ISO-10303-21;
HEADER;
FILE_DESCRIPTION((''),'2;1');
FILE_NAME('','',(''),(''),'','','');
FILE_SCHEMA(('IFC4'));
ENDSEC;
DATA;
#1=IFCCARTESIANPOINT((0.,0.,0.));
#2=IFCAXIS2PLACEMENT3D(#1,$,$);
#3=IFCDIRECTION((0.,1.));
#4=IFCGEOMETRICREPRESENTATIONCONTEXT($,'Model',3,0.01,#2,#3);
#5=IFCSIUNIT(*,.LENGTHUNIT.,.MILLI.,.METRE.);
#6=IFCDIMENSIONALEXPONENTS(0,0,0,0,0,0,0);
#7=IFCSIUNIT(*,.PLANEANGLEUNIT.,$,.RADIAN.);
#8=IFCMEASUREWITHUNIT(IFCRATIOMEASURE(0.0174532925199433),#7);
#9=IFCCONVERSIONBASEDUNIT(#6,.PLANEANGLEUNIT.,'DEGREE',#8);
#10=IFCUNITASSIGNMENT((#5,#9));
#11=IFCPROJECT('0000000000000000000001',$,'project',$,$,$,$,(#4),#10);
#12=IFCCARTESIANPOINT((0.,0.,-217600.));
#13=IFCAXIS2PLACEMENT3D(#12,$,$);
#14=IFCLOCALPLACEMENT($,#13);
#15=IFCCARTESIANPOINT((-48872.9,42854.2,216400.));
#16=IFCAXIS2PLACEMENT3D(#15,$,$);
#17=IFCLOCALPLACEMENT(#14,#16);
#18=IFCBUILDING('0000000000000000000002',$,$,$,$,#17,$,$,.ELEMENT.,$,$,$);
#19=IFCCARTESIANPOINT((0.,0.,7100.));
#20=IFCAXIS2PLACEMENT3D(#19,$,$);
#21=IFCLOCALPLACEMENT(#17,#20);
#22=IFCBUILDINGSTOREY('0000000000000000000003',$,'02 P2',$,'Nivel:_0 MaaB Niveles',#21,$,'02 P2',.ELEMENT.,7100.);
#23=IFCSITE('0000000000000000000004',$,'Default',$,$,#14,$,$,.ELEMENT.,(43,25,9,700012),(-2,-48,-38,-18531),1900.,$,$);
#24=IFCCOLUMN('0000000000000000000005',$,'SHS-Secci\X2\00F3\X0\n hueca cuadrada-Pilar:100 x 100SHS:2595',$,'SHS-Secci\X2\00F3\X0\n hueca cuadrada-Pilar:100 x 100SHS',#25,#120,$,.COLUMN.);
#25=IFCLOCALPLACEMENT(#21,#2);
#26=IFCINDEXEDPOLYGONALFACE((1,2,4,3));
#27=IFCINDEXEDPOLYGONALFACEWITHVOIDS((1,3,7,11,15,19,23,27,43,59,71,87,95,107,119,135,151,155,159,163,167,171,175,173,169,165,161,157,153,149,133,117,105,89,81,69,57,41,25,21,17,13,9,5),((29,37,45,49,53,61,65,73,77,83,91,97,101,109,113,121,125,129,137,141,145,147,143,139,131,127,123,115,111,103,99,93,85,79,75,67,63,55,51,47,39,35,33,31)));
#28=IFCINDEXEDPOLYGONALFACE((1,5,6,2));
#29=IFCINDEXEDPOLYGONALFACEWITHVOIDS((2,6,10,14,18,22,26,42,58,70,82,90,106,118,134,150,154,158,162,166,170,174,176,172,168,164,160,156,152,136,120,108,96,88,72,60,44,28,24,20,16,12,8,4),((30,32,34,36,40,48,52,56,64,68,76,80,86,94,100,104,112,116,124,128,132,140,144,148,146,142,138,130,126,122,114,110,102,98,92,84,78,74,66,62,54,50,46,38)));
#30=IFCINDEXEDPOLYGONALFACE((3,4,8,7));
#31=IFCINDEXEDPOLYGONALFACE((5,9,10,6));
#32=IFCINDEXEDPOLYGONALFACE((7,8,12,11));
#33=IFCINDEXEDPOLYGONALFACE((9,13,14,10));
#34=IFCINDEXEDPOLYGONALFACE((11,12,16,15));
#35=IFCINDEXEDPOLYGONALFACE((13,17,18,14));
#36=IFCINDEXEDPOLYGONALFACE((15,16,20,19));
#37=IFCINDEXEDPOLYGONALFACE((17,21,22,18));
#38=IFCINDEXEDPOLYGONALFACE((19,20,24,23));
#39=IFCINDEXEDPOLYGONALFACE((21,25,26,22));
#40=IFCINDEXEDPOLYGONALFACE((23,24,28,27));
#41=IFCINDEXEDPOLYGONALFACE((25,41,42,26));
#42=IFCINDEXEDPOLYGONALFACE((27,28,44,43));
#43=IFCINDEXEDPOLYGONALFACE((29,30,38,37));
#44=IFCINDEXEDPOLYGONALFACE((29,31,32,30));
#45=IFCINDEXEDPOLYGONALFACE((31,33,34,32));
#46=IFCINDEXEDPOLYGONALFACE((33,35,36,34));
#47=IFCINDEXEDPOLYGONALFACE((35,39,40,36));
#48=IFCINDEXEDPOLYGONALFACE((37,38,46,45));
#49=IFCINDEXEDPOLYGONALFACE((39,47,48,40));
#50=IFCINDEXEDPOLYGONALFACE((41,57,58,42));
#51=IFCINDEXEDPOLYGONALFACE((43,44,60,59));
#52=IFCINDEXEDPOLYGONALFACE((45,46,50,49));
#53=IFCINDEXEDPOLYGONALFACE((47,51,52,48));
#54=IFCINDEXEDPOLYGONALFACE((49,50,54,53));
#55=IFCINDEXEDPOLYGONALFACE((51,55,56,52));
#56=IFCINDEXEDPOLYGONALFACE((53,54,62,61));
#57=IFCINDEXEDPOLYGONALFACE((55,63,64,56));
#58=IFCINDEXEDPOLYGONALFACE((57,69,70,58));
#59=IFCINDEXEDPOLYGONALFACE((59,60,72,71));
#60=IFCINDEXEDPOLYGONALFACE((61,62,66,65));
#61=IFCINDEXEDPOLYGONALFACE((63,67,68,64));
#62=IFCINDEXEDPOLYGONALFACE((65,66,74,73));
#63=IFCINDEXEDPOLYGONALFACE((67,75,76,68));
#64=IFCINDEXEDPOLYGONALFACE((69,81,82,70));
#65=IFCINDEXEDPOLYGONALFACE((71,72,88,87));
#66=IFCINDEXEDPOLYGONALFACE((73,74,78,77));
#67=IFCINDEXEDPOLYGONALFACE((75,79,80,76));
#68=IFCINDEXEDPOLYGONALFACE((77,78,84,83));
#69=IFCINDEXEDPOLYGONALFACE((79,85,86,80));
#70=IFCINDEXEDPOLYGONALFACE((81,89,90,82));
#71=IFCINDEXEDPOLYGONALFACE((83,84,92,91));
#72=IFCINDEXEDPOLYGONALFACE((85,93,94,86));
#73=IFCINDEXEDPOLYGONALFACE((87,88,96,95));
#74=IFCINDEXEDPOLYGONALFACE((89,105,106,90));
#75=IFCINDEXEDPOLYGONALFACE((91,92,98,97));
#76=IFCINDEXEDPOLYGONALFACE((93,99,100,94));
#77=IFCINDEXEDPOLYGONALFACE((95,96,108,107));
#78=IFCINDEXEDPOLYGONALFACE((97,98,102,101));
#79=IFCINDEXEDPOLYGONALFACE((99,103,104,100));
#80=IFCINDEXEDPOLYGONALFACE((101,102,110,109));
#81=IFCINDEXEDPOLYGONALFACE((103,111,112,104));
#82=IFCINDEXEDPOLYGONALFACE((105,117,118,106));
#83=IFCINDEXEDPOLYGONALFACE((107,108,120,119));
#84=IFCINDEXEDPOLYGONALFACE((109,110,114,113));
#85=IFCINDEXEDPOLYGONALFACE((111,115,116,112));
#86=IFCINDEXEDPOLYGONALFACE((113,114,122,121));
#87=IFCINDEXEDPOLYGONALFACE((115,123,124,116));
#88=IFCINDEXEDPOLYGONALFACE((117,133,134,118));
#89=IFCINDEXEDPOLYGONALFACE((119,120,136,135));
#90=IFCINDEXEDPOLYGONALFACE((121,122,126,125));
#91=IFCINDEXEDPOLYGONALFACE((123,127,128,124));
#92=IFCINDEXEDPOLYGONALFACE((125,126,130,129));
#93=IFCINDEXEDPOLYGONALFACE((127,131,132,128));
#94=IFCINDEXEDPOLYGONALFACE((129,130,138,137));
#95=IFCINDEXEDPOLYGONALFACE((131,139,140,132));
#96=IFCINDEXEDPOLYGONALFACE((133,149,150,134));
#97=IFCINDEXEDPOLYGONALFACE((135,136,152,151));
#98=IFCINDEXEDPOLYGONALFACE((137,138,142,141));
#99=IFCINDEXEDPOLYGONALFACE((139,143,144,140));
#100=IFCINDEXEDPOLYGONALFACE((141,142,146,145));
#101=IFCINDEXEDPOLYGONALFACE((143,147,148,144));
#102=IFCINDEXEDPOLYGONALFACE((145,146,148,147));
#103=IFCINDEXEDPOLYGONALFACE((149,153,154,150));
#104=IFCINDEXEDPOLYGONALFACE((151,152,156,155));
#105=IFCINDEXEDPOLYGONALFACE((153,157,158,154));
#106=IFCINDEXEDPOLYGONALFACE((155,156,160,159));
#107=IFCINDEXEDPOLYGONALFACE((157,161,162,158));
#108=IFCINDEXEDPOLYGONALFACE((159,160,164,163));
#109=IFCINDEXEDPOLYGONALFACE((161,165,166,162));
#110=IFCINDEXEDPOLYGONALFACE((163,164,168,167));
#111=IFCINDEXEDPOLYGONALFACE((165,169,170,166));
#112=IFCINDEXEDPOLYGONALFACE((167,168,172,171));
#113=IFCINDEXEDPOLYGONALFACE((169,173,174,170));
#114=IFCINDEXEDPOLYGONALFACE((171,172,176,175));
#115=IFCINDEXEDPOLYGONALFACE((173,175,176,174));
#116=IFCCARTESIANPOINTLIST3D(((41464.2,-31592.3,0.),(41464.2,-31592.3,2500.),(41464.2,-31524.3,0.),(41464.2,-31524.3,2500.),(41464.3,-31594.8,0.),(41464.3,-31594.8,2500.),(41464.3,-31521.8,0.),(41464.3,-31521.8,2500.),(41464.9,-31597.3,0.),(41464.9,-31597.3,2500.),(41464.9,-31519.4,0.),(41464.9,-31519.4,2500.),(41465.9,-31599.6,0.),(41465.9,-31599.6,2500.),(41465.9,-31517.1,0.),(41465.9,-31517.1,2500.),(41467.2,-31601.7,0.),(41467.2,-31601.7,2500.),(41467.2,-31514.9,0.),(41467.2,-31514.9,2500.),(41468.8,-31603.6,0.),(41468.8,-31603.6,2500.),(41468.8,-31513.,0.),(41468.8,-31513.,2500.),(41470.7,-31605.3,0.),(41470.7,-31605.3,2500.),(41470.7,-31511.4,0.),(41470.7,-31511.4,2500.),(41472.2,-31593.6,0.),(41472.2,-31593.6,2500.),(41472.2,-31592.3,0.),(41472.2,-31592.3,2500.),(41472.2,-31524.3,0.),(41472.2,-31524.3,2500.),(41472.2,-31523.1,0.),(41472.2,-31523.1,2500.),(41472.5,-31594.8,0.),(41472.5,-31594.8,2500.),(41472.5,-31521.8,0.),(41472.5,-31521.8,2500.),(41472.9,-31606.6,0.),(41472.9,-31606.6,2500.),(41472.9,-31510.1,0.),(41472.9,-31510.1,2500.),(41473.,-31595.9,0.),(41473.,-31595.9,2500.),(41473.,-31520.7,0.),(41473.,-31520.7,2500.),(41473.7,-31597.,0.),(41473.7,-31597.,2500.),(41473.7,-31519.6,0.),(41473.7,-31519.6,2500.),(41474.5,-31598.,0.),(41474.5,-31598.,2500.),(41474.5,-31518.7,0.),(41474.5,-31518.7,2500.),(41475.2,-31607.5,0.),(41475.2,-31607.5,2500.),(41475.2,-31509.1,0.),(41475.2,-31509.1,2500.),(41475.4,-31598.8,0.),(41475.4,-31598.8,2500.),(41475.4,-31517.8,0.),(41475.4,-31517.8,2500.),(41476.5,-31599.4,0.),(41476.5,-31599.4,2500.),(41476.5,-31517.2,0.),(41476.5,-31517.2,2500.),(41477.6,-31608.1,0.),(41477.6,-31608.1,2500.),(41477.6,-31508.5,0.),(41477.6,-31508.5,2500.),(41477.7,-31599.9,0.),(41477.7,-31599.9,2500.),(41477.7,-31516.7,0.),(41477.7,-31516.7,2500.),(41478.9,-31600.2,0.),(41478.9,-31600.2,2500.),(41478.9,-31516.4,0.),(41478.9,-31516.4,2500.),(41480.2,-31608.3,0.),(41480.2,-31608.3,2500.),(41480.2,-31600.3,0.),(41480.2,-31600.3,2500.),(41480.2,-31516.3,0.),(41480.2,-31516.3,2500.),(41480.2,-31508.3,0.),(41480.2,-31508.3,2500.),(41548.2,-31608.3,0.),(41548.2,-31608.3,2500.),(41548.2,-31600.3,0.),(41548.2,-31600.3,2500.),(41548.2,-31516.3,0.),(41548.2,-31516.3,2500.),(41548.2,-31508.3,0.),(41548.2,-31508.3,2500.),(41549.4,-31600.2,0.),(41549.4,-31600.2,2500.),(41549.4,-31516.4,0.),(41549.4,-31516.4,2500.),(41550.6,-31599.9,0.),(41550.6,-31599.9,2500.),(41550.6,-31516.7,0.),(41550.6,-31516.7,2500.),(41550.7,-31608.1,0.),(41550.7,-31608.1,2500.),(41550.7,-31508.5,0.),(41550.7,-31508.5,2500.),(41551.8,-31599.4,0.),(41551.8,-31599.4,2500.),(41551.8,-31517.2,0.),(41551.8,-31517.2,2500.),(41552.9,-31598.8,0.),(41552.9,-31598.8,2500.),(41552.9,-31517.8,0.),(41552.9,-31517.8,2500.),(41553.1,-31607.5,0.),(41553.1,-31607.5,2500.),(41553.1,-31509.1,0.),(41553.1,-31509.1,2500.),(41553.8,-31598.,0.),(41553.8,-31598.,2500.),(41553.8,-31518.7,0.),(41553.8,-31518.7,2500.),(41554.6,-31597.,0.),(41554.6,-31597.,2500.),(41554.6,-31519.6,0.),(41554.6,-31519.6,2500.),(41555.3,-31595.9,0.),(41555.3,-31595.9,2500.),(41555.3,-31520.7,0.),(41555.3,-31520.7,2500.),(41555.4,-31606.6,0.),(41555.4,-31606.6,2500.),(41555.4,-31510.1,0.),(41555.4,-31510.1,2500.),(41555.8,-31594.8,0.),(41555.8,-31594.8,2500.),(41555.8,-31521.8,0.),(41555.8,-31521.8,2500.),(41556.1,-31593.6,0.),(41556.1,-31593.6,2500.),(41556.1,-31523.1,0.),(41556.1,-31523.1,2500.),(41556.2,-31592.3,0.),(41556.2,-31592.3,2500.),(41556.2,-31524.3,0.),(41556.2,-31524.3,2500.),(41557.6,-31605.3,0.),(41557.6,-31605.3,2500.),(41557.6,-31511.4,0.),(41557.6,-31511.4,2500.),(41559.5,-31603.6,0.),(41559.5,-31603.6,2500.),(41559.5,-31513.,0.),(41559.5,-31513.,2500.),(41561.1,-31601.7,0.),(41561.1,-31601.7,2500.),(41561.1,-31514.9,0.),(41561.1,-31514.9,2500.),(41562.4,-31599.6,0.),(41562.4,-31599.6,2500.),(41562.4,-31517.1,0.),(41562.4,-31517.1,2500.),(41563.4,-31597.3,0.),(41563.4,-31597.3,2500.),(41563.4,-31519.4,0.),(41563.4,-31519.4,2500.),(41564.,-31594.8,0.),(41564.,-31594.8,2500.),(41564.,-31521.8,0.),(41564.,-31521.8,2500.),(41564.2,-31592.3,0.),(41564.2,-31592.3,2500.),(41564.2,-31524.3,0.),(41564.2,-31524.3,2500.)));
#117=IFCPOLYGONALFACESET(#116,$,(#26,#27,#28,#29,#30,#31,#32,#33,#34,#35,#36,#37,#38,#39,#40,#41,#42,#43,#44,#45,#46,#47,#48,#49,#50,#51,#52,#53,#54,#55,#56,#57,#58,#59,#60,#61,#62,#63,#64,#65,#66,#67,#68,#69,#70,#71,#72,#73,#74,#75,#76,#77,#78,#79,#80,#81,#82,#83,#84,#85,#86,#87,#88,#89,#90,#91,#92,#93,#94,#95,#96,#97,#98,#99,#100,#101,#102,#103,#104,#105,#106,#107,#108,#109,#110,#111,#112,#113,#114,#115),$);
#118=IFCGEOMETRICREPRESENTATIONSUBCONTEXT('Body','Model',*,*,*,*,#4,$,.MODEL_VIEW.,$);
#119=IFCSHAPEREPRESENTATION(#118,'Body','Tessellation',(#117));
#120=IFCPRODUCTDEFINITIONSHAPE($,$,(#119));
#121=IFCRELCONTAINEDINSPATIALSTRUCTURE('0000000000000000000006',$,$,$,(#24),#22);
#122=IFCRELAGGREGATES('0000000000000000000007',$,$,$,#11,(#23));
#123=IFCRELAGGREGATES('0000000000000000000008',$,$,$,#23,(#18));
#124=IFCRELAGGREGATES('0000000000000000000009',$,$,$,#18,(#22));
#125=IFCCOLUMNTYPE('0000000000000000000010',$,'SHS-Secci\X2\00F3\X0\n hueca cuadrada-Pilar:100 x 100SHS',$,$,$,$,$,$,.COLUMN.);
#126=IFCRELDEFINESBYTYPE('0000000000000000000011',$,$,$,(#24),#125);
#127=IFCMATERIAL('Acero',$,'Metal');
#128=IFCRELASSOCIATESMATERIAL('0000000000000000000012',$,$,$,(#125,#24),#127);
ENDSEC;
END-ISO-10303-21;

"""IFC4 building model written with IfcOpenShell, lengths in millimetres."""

from ifc_helpers import new_model, entity, si_unit, converted_unit, direction, frame, origin, place, context, subcontext, project, spatial, indexed_curve, outline, extrude, source, transform, mapped, material, type_object, type_shapes, element, save


model = new_model("IFC4")

# Units and contexts
model_context = context("Model", 3, precision=0.01, world=origin(), true_north=direction((0.0, 1.0)))
body_context = subcontext(model_context, "Body", "Model", "MODEL_VIEW")
ifc_project = project(units=[si_unit("LENGTHUNIT", "METRE", prefix="MILLI"), converted_unit("PLANEANGLEUNIT", "DEGREE", entity("IfcRatioMeasure", 0.0174532925199433), si_unit("PLANEANGLEUNIT", "RADIAN"), dimensions=[0, 0, 0, 0, 0, 0, 0])], contexts=[model_context])

# Site, building, storey
site_placement = place(None, frame((0.0, 0.0, -217600.0)))
site = spatial("IfcSite", under=ifc_project, at=site_placement, Name="Default", CompositionType="ELEMENT", RefLatitude=(43, 25, 9, 700012), RefLongitude=(-2, -48, -38, -18531), RefElevation=1900.0)
building_placement = place(site_placement, frame((-48872.9, 42854.2, 216400.0)))
building = spatial("IfcBuilding", under=site, at=building_placement, CompositionType="ELEMENT")
storey_placement = place(building_placement, frame((0.0, 0.0, 7100.0)))
storey = spatial("IfcBuildingStorey", under=building, at=storey_placement, Name="02 P2", ObjectType="Nivel:_0 MaaB Niveles", LongName="02 P2", CompositionType="ELEMENT", Elevation=7100.0)

# Column
ifc_material_1 = material(Name="Acero", Category="Metal")
column_type_1 = type_object("IfcColumnType", Name="SHS-Sección hueca cuadrada-Pilar:100 x 100SHS", PredefinedType="COLUMN", material=ifc_material_1)
shared_shape_1 = source(origin(), body_context, "Body", "SweptSolid", [
    extrude(outline(indexed_curve([(-34.0, -50.0), (34.0, -50.0), (36.5, -49.8), (38.9, -49.2), (41.3, -48.3), (43.4, -46.9), (45.3, -45.3), (46.9, -43.4), (48.3, -41.3), (49.2, -38.9), (49.8, -36.5), (50.0, -34.0), (50.0, 34.0), (49.8, 36.5), (49.2, 38.9), (48.3, 41.3), (46.9, 43.4), (45.3, 45.3), (43.4, 46.9), (41.3, 48.3), (38.9, 49.2), (36.5, 49.8), (34.0, 50.0), (-34.0, 50.0), (-36.5, 49.8), (-38.9, 49.2), (-41.3, 48.3), (-43.4, 46.9), (-45.3, 45.3), (-46.9, 43.4), (-48.3, 41.3), (-49.2, 38.9), (-49.8, 36.5), (-50.0, 34.0), (-50.0, -34.0), (-49.8, -36.5), (-49.2, -38.9), (-48.3, -41.3), (-46.9, -43.4), (-45.3, -45.3), (-43.4, -46.9), (-41.3, -48.3), (-38.9, -49.2), (-36.5, -49.8), (-34.0, -50.0)], self_intersect=False), holes=[indexed_curve([(-42.0, 34.0), (-41.9, 35.3), (-41.6, 36.5), (-41.1, 37.6), (-40.5, 38.7), (-39.7, 39.7), (-38.7, 40.5), (-37.6, 41.1), (-36.5, 41.6), (-35.3, 41.9), (-34.0, 42.0), (34.0, 42.0), (35.3, 41.9), (36.5, 41.6), (37.6, 41.1), (38.7, 40.5), (39.7, 39.7), (40.5, 38.7), (41.1, 37.6), (41.6, 36.5), (41.9, 35.3), (42.0, 34.0), (42.0, -34.0), (41.9, -35.3), (41.6, -36.5), (41.1, -37.6), (40.5, -38.7), (39.7, -39.7), (38.7, -40.5), (37.6, -41.1), (36.5, -41.6), (35.3, -41.9), (34.0, -42.0), (-34.0, -42.0), (-35.3, -41.9), (-36.5, -41.6), (-37.6, -41.1), (-38.7, -40.5), (-39.7, -39.7), (-40.5, -38.7), (-41.1, -37.6), (-41.6, -36.5), (-41.9, -35.3), (-42.0, -34.0), (-42.0, 34.0)], self_intersect=False)]), frame((0.0, 0.0, 7100.0), z_axis=(0.0, 0.0, 1.0), x_axis=(0.0, 1.0, 0.0)), (0.0, 0.0, 1.0), 2500.0),
])
type_shapes(column_type_1, [shared_shape_1])
column_1_placement = place(storey_placement, frame((41514.2, -31558.3, -7100.0), z_axis=(0.0, 0.0, 1.0), x_axis=(0.0, -1.0, 0.0)))
element("IfcColumn", 1, at=column_1_placement, inside=storey, type_object=column_type_1, material=ifc_material_1, Name="SHS-Sección hueca cuadrada-Pilar:100 x 100SHS:2595", ObjectType="SHS-Sección hueca cuadrada-Pilar:100 x 100SHS", PredefinedType="COLUMN", context=body_context, shape_type="MappedRepresentation", body=[
    mapped(shared_shape_1, transform((0.0, 0.0, 0.0), scale=1.0)),
])

save(model, "model.ifc")
